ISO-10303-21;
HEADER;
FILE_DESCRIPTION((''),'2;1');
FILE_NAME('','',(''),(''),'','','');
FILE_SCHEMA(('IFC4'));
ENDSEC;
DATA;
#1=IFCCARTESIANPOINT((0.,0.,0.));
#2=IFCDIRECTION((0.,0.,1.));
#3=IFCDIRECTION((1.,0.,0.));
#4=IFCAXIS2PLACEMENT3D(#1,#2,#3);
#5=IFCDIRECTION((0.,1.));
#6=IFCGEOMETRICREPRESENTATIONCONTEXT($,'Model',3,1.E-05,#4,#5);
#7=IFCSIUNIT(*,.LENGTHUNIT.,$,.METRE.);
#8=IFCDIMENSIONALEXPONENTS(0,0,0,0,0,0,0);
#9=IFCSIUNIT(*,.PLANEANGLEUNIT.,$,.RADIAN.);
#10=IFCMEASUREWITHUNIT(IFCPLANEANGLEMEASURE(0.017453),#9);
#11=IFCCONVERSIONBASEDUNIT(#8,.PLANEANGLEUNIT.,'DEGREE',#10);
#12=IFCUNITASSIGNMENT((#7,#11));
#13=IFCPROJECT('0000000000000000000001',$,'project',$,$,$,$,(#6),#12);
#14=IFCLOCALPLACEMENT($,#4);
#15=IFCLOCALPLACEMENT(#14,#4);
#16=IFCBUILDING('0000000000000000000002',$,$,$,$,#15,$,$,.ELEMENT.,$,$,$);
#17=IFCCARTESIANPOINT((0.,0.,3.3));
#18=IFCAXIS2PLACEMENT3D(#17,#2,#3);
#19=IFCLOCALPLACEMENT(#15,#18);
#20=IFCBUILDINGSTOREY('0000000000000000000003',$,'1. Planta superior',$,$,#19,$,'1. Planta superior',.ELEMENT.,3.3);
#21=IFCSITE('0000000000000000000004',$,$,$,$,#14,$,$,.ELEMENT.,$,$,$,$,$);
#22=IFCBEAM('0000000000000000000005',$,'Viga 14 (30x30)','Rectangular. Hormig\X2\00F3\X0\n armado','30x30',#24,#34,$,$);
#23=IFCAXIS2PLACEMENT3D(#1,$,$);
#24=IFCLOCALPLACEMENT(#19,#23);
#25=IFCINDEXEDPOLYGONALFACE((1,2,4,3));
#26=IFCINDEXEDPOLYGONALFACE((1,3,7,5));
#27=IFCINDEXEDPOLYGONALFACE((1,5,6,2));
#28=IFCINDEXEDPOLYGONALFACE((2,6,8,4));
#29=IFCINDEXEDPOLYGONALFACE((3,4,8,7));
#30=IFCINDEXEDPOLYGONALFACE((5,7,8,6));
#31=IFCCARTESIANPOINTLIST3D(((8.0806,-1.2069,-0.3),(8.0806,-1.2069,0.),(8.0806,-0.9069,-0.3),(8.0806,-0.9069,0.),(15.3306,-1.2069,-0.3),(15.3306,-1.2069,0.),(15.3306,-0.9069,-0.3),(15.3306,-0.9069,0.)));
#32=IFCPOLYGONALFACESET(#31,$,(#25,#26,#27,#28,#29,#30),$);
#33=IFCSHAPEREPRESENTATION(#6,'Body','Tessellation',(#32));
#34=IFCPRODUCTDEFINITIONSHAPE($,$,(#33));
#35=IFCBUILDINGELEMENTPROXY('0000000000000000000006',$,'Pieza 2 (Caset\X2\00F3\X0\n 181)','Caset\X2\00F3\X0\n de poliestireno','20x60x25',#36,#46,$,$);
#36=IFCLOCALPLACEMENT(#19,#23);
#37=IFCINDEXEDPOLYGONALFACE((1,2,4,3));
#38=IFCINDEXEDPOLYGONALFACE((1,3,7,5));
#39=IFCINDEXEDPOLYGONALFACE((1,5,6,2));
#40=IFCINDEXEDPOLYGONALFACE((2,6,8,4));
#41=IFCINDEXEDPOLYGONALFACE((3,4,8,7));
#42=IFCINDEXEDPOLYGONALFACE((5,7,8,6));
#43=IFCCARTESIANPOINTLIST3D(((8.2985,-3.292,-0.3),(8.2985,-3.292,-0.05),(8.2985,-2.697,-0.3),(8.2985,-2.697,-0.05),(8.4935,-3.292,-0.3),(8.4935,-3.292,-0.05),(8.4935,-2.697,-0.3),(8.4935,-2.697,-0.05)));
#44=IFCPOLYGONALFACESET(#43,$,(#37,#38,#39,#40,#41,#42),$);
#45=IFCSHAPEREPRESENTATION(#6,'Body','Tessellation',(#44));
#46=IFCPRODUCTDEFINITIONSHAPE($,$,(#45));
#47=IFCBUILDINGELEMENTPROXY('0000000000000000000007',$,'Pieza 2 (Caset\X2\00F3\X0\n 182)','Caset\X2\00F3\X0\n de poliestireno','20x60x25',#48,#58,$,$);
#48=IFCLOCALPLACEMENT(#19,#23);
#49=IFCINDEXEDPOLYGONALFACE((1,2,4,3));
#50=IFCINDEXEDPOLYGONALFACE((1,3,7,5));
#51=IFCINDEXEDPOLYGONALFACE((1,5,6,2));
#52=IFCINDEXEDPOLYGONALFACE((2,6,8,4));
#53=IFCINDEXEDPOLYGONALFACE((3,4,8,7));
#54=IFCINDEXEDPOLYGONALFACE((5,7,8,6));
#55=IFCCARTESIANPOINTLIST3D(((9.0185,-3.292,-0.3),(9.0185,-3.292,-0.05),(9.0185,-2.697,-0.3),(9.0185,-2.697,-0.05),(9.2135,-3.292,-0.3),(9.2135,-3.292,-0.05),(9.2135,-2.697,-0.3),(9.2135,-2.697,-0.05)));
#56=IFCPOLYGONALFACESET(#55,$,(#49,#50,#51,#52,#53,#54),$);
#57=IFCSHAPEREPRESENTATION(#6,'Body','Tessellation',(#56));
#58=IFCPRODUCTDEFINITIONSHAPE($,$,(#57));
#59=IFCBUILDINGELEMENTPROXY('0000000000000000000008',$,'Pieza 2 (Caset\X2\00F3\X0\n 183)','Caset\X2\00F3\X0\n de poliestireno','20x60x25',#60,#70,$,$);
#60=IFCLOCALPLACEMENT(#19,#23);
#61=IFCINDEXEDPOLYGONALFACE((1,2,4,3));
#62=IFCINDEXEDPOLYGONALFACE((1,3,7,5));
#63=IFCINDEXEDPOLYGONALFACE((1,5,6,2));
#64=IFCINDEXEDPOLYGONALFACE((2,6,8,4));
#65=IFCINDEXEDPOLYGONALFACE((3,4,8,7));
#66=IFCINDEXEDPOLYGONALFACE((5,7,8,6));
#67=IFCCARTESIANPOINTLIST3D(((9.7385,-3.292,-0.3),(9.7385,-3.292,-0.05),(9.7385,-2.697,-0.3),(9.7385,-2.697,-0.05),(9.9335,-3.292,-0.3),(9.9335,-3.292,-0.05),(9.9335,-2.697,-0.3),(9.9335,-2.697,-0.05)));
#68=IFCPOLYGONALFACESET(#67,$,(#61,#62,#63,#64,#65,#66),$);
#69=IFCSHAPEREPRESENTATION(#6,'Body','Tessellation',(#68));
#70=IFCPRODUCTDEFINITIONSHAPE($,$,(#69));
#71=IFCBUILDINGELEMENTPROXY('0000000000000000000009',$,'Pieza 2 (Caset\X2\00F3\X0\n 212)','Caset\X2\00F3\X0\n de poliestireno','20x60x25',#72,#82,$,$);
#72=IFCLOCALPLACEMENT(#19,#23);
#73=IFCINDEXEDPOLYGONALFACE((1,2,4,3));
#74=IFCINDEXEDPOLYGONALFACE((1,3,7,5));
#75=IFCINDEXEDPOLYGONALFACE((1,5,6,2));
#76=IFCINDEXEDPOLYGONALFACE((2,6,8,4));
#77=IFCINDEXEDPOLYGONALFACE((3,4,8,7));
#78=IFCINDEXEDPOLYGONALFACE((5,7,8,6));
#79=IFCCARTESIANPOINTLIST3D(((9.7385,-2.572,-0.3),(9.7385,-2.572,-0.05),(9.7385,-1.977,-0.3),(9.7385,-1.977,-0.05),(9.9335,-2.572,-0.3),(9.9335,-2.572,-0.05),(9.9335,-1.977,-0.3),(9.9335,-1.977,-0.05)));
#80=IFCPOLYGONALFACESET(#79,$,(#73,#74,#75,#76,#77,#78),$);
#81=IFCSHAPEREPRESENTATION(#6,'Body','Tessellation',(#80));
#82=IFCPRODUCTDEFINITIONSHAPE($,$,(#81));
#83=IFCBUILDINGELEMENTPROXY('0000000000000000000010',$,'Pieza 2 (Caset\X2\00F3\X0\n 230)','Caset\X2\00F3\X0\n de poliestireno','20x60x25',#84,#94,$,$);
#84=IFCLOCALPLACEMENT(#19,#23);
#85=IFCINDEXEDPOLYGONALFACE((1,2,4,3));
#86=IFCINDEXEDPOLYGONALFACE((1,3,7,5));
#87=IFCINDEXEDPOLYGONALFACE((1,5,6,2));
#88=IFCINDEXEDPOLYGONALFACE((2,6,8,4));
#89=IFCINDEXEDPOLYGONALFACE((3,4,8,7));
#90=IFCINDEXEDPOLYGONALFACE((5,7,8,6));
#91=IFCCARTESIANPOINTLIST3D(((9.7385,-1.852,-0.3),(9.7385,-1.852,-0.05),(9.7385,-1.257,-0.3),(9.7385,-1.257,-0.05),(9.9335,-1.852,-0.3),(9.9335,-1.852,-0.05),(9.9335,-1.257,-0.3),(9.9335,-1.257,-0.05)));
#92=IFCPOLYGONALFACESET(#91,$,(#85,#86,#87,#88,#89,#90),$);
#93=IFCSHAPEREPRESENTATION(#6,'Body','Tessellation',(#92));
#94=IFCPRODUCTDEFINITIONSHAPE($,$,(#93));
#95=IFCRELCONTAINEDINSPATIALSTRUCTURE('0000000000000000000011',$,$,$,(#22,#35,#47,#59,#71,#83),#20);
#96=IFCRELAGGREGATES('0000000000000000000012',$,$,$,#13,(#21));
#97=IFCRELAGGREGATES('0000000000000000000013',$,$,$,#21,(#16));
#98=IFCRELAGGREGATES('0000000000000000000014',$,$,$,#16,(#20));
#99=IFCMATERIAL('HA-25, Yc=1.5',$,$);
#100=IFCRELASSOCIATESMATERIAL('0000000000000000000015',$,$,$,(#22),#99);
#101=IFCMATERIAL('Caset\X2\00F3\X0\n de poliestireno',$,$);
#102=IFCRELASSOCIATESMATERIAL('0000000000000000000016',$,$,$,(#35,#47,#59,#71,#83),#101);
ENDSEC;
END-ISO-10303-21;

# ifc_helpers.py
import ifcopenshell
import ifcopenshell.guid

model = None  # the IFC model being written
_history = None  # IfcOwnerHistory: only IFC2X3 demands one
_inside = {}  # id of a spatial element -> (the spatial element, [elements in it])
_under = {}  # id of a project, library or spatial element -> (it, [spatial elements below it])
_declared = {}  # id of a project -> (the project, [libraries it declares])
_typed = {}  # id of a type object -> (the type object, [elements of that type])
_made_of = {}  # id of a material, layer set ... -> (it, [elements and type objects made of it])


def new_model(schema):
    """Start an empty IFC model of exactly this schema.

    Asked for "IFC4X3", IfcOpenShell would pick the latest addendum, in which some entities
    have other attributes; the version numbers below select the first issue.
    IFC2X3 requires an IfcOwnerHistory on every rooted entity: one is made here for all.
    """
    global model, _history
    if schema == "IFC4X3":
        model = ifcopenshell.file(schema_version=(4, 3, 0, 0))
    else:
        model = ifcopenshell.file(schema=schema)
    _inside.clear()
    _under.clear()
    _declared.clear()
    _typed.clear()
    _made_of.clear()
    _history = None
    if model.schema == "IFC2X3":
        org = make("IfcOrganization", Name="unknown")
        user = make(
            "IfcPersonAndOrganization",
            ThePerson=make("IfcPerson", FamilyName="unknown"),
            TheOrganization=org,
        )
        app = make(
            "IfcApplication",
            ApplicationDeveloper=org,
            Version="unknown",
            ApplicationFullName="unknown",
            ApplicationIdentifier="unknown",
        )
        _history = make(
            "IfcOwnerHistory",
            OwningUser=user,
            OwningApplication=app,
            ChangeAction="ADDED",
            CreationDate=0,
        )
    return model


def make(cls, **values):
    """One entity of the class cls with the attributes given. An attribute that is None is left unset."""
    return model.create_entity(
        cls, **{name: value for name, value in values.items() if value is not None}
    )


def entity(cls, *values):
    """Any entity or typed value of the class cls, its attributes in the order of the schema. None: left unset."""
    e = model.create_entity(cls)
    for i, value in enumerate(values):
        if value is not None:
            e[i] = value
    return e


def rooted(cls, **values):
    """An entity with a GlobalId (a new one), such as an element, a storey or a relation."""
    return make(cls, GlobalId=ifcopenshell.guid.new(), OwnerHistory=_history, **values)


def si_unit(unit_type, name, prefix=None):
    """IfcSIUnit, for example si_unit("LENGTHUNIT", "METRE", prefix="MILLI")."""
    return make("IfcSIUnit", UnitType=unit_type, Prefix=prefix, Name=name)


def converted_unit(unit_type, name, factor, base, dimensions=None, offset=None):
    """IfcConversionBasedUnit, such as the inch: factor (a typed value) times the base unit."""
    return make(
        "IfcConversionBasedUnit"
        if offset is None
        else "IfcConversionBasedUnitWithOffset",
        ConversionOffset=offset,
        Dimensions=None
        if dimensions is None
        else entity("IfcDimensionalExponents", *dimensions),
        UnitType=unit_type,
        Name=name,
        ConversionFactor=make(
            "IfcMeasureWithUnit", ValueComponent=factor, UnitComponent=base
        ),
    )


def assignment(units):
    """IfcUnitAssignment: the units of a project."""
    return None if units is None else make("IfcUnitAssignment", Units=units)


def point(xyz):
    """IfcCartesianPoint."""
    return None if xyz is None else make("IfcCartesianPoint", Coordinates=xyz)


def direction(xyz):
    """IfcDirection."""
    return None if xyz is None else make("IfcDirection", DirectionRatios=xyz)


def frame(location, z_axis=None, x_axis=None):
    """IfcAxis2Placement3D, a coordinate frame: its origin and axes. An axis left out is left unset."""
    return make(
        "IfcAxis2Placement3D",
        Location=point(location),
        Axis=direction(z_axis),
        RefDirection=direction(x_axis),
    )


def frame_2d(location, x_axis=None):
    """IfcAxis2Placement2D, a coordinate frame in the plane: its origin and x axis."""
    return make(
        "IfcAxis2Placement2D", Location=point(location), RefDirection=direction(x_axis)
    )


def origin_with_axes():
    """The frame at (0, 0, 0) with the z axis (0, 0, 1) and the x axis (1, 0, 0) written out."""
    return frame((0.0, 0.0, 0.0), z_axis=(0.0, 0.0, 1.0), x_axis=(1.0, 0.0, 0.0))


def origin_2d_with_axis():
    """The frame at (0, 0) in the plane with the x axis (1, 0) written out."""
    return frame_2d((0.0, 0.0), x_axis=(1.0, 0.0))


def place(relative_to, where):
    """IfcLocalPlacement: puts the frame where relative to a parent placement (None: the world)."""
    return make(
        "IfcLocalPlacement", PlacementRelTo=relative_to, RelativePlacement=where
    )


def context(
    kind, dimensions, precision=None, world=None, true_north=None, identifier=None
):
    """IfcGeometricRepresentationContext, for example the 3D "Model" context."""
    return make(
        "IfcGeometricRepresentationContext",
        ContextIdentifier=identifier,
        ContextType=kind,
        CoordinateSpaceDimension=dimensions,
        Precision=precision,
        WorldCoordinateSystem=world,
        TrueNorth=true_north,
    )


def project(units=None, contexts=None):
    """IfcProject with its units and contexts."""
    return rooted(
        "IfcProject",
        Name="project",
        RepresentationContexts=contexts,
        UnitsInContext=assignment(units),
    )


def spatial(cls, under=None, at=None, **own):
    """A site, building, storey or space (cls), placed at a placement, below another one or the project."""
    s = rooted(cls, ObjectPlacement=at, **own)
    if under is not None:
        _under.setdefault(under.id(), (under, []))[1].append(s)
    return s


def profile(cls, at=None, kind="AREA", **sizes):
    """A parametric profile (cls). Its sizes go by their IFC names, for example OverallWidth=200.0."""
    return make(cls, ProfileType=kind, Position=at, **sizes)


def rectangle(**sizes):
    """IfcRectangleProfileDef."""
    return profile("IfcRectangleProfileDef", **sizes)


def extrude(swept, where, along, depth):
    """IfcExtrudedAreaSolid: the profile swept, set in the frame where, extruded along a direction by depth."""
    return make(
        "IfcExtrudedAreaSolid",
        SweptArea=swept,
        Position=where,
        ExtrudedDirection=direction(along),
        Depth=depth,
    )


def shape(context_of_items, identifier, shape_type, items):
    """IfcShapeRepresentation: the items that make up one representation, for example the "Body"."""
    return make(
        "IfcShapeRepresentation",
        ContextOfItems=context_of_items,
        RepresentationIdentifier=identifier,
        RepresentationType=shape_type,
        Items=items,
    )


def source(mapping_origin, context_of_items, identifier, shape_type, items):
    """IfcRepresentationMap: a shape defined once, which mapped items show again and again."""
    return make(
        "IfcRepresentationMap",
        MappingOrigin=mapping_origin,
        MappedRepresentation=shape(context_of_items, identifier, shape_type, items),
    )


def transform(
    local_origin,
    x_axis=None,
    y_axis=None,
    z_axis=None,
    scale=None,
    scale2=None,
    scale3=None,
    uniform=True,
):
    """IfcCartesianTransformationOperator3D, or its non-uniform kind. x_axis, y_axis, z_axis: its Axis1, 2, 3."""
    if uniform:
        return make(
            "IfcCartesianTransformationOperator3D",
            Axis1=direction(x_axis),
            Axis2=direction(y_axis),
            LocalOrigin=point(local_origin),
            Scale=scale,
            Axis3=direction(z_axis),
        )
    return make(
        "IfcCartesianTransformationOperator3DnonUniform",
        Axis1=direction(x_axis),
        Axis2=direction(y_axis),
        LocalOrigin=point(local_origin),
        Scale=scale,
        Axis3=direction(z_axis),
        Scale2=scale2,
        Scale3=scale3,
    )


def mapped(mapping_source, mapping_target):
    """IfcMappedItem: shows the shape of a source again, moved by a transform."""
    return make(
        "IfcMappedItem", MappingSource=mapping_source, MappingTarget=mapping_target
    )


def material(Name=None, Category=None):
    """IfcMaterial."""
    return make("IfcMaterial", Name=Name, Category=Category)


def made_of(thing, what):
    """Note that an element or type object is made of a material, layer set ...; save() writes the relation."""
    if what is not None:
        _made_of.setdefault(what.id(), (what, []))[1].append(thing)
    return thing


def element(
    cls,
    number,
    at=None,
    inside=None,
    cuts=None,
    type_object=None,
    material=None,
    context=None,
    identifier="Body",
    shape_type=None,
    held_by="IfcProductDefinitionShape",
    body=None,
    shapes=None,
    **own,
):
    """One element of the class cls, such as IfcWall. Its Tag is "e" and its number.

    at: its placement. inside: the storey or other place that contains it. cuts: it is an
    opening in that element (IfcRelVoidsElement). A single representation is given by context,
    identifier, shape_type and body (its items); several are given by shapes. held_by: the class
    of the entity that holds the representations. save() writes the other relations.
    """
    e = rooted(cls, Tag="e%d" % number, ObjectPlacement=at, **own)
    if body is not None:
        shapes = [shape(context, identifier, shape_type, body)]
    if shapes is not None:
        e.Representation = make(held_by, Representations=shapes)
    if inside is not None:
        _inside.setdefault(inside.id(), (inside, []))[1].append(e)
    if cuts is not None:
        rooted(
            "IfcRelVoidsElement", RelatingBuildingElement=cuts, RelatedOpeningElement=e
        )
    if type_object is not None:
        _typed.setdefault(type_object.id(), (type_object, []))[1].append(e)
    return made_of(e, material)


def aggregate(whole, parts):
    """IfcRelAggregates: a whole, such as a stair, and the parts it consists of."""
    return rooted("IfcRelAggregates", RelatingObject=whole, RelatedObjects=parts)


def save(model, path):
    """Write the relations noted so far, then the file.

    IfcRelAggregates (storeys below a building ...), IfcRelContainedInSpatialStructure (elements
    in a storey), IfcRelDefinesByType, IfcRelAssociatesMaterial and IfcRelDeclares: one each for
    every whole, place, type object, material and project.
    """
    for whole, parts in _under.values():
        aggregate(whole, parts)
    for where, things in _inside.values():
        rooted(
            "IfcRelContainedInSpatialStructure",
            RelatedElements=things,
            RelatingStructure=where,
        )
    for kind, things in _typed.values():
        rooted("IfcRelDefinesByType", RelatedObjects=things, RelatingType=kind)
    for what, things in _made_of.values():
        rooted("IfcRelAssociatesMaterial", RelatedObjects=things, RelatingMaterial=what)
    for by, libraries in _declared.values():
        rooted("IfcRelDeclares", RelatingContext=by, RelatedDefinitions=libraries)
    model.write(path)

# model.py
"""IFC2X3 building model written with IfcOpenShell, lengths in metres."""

from ifc_helpers import new_model, entity, si_unit, converted_unit, direction, frame, frame_2d, origin_with_axes, origin_2d_with_axis, place, context, project, spatial, rectangle, extrude, source, transform, mapped, material, element, save


model = new_model("IFC2X3")

# Units and contexts
model_context = context("Model", 3, precision=1e-05, world=origin_with_axes(), true_north=direction((0.0, 1.0)))
ifc_project = project(units=[si_unit("LENGTHUNIT", "METRE"), converted_unit("PLANEANGLEUNIT", "DEGREE", entity("IfcPlaneAngleMeasure", 0.017453), si_unit("PLANEANGLEUNIT", "RADIAN"), dimensions=[0, 0, 0, 0, 0, 0, 0])], contexts=[model_context])

# Site, building, storey
site_placement = place(None, origin_with_axes())
site = spatial("IfcSite", under=ifc_project, at=site_placement, CompositionType="ELEMENT")
building_placement = place(site_placement, origin_with_axes())
building = spatial("IfcBuilding", under=site, at=building_placement, CompositionType="ELEMENT")
storey_placement = place(building_placement, frame((0.0, 0.0, 3.3), z_axis=(0.0, 0.0, 1.0), x_axis=(1.0, 0.0, 0.0)))
storey = spatial("IfcBuildingStorey", under=building, at=storey_placement, Name="1. Planta superior", LongName="1. Planta superior", CompositionType="ELEMENT", Elevation=3.3)

# Beam
ifc_material_1 = material(Name="HA-25, Yc=1.5")
beam_placement = place(storey_placement, frame((8.0806, -1.0569, 0.0), z_axis=(1.0, 0.0, 0.0), x_axis=(0.0, 1.0, 0.0)))
element("IfcBeam", 1, at=beam_placement, inside=storey, material=ifc_material_1, Name="Viga 14 (30x30)", Description="Rectangular. Hormigón armado", ObjectType="30x30", context=model_context, shape_type="SweptSolid", body=[
    extrude(rectangle(XDim=0.3, YDim=0.3, at=frame_2d((0.0, -0.15), x_axis=(1.0, 0.0))), origin_with_axes(), (0.0, 0.0, 1.0), 7.25),
])

# Building element proxies
ifc_material_2 = material(Name="Casetón de poliestireno")
shared_shape = source(origin_with_axes(), model_context, "Body", "SweptSolid", [
    extrude(rectangle(XDim=0.195, YDim=0.25, at=origin_2d_with_axis()), origin_with_axes(), (0.0, 0.0, 1.0), 0.595),
])
placement_1 = place(storey_placement, frame((8.396, -3.292, -0.175), z_axis=(0.0, 1.0, 0.0), x_axis=(-1.0, 0.0, 0.0)))
for number, where, z_axis, x_axis, name in (
    (2, (0.0, 0.0, 0.0), (0.0, 0.0, 1.0), (1.0, 0.0, 0.0), "Pieza 2 (Casetón 181)"),
):
    element("IfcBuildingElementProxy", number, at=place(placement_1, frame(where, z_axis=z_axis, x_axis=x_axis)), inside=storey, material=ifc_material_2, Name=name, Description="Casetón de poliestireno", ObjectType="20x60x25", context=model_context, shape_type="MappedRepresentation", body=[
        mapped(shared_shape, transform((0.0, 0.0, 0.0), x_axis=(1.0, 0.0, 0.0), y_axis=(0.0, 1.0, 0.0), z_axis=(0.0, 0.0, 1.0))),
    ])
placement_2 = place(storey_placement, frame((9.116, -3.292, -0.175), z_axis=(0.0, 1.0, 0.0), x_axis=(-1.0, 0.0, 0.0)))
for number, where, z_axis, x_axis, name in (
    (3, (0.0, 0.0, 0.0), (0.0, 0.0, 1.0), (1.0, 0.0, 0.0), "Pieza 2 (Casetón 182)"),
):
    element("IfcBuildingElementProxy", number, at=place(placement_2, frame(where, z_axis=z_axis, x_axis=x_axis)), inside=storey, material=ifc_material_2, Name=name, Description="Casetón de poliestireno", ObjectType="20x60x25", context=model_context, shape_type="MappedRepresentation", body=[
        mapped(shared_shape, transform((0.0, 0.0, 0.0), x_axis=(1.0, 0.0, 0.0), y_axis=(0.0, 1.0, 0.0), z_axis=(0.0, 0.0, 1.0))),
    ])
placement_3 = place(storey_placement, frame((9.836, -3.292, -0.175), z_axis=(0.0, 1.0, 0.0), x_axis=(-1.0, 0.0, 0.0)))
for number, where, z_axis, x_axis, name in (
    (4, (0.0, 0.0, 0.0), (0.0, 0.0, 1.0), (1.0, 0.0, 0.0), "Pieza 2 (Casetón 183)"),
):
    element("IfcBuildingElementProxy", number, at=place(placement_3, frame(where, z_axis=z_axis, x_axis=x_axis)), inside=storey, material=ifc_material_2, Name=name, Description="Casetón de poliestireno", ObjectType="20x60x25", context=model_context, shape_type="MappedRepresentation", body=[
        mapped(shared_shape, transform((0.0, 0.0, 0.0), x_axis=(1.0, 0.0, 0.0), y_axis=(0.0, 1.0, 0.0), z_axis=(0.0, 0.0, 1.0))),
    ])
placement_4 = place(storey_placement, frame((9.836, -2.572, -0.175), z_axis=(0.0, 1.0, 0.0), x_axis=(-1.0, 0.0, 0.0)))
for number, where, z_axis, x_axis, name in (
    (5, (0.0, 0.0, 0.0), (0.0, 0.0, 1.0), (1.0, 0.0, 0.0), "Pieza 2 (Casetón 212)"),
):
    element("IfcBuildingElementProxy", number, at=place(placement_4, frame(where, z_axis=z_axis, x_axis=x_axis)), inside=storey, material=ifc_material_2, Name=name, Description="Casetón de poliestireno", ObjectType="20x60x25", context=model_context, shape_type="MappedRepresentation", body=[
        mapped(shared_shape, transform((0.0, 0.0, 0.0), x_axis=(1.0, 0.0, 0.0), y_axis=(0.0, 1.0, 0.0), z_axis=(0.0, 0.0, 1.0))),
    ])
placement_5 = place(storey_placement, frame((9.836, -1.852, -0.175), z_axis=(0.0, 1.0, 0.0), x_axis=(-1.0, 0.0, 0.0)))
for number, where, z_axis, x_axis, name in (
    (6, (0.0, 0.0, 0.0), (0.0, 0.0, 1.0), (1.0, 0.0, 0.0), "Pieza 2 (Casetón 230)"),
):
    element("IfcBuildingElementProxy", number, at=place(placement_5, frame(where, z_axis=z_axis, x_axis=x_axis)), inside=storey, material=ifc_material_2, Name=name, Description="Casetón de poliestireno", ObjectType="20x60x25", context=model_context, shape_type="MappedRepresentation", body=[
        mapped(shared_shape, transform((0.0, 0.0, 0.0), x_axis=(1.0, 0.0, 0.0), y_axis=(0.0, 1.0, 0.0), z_axis=(0.0, 0.0, 1.0))),
    ])

save(model, "model.ifc")
